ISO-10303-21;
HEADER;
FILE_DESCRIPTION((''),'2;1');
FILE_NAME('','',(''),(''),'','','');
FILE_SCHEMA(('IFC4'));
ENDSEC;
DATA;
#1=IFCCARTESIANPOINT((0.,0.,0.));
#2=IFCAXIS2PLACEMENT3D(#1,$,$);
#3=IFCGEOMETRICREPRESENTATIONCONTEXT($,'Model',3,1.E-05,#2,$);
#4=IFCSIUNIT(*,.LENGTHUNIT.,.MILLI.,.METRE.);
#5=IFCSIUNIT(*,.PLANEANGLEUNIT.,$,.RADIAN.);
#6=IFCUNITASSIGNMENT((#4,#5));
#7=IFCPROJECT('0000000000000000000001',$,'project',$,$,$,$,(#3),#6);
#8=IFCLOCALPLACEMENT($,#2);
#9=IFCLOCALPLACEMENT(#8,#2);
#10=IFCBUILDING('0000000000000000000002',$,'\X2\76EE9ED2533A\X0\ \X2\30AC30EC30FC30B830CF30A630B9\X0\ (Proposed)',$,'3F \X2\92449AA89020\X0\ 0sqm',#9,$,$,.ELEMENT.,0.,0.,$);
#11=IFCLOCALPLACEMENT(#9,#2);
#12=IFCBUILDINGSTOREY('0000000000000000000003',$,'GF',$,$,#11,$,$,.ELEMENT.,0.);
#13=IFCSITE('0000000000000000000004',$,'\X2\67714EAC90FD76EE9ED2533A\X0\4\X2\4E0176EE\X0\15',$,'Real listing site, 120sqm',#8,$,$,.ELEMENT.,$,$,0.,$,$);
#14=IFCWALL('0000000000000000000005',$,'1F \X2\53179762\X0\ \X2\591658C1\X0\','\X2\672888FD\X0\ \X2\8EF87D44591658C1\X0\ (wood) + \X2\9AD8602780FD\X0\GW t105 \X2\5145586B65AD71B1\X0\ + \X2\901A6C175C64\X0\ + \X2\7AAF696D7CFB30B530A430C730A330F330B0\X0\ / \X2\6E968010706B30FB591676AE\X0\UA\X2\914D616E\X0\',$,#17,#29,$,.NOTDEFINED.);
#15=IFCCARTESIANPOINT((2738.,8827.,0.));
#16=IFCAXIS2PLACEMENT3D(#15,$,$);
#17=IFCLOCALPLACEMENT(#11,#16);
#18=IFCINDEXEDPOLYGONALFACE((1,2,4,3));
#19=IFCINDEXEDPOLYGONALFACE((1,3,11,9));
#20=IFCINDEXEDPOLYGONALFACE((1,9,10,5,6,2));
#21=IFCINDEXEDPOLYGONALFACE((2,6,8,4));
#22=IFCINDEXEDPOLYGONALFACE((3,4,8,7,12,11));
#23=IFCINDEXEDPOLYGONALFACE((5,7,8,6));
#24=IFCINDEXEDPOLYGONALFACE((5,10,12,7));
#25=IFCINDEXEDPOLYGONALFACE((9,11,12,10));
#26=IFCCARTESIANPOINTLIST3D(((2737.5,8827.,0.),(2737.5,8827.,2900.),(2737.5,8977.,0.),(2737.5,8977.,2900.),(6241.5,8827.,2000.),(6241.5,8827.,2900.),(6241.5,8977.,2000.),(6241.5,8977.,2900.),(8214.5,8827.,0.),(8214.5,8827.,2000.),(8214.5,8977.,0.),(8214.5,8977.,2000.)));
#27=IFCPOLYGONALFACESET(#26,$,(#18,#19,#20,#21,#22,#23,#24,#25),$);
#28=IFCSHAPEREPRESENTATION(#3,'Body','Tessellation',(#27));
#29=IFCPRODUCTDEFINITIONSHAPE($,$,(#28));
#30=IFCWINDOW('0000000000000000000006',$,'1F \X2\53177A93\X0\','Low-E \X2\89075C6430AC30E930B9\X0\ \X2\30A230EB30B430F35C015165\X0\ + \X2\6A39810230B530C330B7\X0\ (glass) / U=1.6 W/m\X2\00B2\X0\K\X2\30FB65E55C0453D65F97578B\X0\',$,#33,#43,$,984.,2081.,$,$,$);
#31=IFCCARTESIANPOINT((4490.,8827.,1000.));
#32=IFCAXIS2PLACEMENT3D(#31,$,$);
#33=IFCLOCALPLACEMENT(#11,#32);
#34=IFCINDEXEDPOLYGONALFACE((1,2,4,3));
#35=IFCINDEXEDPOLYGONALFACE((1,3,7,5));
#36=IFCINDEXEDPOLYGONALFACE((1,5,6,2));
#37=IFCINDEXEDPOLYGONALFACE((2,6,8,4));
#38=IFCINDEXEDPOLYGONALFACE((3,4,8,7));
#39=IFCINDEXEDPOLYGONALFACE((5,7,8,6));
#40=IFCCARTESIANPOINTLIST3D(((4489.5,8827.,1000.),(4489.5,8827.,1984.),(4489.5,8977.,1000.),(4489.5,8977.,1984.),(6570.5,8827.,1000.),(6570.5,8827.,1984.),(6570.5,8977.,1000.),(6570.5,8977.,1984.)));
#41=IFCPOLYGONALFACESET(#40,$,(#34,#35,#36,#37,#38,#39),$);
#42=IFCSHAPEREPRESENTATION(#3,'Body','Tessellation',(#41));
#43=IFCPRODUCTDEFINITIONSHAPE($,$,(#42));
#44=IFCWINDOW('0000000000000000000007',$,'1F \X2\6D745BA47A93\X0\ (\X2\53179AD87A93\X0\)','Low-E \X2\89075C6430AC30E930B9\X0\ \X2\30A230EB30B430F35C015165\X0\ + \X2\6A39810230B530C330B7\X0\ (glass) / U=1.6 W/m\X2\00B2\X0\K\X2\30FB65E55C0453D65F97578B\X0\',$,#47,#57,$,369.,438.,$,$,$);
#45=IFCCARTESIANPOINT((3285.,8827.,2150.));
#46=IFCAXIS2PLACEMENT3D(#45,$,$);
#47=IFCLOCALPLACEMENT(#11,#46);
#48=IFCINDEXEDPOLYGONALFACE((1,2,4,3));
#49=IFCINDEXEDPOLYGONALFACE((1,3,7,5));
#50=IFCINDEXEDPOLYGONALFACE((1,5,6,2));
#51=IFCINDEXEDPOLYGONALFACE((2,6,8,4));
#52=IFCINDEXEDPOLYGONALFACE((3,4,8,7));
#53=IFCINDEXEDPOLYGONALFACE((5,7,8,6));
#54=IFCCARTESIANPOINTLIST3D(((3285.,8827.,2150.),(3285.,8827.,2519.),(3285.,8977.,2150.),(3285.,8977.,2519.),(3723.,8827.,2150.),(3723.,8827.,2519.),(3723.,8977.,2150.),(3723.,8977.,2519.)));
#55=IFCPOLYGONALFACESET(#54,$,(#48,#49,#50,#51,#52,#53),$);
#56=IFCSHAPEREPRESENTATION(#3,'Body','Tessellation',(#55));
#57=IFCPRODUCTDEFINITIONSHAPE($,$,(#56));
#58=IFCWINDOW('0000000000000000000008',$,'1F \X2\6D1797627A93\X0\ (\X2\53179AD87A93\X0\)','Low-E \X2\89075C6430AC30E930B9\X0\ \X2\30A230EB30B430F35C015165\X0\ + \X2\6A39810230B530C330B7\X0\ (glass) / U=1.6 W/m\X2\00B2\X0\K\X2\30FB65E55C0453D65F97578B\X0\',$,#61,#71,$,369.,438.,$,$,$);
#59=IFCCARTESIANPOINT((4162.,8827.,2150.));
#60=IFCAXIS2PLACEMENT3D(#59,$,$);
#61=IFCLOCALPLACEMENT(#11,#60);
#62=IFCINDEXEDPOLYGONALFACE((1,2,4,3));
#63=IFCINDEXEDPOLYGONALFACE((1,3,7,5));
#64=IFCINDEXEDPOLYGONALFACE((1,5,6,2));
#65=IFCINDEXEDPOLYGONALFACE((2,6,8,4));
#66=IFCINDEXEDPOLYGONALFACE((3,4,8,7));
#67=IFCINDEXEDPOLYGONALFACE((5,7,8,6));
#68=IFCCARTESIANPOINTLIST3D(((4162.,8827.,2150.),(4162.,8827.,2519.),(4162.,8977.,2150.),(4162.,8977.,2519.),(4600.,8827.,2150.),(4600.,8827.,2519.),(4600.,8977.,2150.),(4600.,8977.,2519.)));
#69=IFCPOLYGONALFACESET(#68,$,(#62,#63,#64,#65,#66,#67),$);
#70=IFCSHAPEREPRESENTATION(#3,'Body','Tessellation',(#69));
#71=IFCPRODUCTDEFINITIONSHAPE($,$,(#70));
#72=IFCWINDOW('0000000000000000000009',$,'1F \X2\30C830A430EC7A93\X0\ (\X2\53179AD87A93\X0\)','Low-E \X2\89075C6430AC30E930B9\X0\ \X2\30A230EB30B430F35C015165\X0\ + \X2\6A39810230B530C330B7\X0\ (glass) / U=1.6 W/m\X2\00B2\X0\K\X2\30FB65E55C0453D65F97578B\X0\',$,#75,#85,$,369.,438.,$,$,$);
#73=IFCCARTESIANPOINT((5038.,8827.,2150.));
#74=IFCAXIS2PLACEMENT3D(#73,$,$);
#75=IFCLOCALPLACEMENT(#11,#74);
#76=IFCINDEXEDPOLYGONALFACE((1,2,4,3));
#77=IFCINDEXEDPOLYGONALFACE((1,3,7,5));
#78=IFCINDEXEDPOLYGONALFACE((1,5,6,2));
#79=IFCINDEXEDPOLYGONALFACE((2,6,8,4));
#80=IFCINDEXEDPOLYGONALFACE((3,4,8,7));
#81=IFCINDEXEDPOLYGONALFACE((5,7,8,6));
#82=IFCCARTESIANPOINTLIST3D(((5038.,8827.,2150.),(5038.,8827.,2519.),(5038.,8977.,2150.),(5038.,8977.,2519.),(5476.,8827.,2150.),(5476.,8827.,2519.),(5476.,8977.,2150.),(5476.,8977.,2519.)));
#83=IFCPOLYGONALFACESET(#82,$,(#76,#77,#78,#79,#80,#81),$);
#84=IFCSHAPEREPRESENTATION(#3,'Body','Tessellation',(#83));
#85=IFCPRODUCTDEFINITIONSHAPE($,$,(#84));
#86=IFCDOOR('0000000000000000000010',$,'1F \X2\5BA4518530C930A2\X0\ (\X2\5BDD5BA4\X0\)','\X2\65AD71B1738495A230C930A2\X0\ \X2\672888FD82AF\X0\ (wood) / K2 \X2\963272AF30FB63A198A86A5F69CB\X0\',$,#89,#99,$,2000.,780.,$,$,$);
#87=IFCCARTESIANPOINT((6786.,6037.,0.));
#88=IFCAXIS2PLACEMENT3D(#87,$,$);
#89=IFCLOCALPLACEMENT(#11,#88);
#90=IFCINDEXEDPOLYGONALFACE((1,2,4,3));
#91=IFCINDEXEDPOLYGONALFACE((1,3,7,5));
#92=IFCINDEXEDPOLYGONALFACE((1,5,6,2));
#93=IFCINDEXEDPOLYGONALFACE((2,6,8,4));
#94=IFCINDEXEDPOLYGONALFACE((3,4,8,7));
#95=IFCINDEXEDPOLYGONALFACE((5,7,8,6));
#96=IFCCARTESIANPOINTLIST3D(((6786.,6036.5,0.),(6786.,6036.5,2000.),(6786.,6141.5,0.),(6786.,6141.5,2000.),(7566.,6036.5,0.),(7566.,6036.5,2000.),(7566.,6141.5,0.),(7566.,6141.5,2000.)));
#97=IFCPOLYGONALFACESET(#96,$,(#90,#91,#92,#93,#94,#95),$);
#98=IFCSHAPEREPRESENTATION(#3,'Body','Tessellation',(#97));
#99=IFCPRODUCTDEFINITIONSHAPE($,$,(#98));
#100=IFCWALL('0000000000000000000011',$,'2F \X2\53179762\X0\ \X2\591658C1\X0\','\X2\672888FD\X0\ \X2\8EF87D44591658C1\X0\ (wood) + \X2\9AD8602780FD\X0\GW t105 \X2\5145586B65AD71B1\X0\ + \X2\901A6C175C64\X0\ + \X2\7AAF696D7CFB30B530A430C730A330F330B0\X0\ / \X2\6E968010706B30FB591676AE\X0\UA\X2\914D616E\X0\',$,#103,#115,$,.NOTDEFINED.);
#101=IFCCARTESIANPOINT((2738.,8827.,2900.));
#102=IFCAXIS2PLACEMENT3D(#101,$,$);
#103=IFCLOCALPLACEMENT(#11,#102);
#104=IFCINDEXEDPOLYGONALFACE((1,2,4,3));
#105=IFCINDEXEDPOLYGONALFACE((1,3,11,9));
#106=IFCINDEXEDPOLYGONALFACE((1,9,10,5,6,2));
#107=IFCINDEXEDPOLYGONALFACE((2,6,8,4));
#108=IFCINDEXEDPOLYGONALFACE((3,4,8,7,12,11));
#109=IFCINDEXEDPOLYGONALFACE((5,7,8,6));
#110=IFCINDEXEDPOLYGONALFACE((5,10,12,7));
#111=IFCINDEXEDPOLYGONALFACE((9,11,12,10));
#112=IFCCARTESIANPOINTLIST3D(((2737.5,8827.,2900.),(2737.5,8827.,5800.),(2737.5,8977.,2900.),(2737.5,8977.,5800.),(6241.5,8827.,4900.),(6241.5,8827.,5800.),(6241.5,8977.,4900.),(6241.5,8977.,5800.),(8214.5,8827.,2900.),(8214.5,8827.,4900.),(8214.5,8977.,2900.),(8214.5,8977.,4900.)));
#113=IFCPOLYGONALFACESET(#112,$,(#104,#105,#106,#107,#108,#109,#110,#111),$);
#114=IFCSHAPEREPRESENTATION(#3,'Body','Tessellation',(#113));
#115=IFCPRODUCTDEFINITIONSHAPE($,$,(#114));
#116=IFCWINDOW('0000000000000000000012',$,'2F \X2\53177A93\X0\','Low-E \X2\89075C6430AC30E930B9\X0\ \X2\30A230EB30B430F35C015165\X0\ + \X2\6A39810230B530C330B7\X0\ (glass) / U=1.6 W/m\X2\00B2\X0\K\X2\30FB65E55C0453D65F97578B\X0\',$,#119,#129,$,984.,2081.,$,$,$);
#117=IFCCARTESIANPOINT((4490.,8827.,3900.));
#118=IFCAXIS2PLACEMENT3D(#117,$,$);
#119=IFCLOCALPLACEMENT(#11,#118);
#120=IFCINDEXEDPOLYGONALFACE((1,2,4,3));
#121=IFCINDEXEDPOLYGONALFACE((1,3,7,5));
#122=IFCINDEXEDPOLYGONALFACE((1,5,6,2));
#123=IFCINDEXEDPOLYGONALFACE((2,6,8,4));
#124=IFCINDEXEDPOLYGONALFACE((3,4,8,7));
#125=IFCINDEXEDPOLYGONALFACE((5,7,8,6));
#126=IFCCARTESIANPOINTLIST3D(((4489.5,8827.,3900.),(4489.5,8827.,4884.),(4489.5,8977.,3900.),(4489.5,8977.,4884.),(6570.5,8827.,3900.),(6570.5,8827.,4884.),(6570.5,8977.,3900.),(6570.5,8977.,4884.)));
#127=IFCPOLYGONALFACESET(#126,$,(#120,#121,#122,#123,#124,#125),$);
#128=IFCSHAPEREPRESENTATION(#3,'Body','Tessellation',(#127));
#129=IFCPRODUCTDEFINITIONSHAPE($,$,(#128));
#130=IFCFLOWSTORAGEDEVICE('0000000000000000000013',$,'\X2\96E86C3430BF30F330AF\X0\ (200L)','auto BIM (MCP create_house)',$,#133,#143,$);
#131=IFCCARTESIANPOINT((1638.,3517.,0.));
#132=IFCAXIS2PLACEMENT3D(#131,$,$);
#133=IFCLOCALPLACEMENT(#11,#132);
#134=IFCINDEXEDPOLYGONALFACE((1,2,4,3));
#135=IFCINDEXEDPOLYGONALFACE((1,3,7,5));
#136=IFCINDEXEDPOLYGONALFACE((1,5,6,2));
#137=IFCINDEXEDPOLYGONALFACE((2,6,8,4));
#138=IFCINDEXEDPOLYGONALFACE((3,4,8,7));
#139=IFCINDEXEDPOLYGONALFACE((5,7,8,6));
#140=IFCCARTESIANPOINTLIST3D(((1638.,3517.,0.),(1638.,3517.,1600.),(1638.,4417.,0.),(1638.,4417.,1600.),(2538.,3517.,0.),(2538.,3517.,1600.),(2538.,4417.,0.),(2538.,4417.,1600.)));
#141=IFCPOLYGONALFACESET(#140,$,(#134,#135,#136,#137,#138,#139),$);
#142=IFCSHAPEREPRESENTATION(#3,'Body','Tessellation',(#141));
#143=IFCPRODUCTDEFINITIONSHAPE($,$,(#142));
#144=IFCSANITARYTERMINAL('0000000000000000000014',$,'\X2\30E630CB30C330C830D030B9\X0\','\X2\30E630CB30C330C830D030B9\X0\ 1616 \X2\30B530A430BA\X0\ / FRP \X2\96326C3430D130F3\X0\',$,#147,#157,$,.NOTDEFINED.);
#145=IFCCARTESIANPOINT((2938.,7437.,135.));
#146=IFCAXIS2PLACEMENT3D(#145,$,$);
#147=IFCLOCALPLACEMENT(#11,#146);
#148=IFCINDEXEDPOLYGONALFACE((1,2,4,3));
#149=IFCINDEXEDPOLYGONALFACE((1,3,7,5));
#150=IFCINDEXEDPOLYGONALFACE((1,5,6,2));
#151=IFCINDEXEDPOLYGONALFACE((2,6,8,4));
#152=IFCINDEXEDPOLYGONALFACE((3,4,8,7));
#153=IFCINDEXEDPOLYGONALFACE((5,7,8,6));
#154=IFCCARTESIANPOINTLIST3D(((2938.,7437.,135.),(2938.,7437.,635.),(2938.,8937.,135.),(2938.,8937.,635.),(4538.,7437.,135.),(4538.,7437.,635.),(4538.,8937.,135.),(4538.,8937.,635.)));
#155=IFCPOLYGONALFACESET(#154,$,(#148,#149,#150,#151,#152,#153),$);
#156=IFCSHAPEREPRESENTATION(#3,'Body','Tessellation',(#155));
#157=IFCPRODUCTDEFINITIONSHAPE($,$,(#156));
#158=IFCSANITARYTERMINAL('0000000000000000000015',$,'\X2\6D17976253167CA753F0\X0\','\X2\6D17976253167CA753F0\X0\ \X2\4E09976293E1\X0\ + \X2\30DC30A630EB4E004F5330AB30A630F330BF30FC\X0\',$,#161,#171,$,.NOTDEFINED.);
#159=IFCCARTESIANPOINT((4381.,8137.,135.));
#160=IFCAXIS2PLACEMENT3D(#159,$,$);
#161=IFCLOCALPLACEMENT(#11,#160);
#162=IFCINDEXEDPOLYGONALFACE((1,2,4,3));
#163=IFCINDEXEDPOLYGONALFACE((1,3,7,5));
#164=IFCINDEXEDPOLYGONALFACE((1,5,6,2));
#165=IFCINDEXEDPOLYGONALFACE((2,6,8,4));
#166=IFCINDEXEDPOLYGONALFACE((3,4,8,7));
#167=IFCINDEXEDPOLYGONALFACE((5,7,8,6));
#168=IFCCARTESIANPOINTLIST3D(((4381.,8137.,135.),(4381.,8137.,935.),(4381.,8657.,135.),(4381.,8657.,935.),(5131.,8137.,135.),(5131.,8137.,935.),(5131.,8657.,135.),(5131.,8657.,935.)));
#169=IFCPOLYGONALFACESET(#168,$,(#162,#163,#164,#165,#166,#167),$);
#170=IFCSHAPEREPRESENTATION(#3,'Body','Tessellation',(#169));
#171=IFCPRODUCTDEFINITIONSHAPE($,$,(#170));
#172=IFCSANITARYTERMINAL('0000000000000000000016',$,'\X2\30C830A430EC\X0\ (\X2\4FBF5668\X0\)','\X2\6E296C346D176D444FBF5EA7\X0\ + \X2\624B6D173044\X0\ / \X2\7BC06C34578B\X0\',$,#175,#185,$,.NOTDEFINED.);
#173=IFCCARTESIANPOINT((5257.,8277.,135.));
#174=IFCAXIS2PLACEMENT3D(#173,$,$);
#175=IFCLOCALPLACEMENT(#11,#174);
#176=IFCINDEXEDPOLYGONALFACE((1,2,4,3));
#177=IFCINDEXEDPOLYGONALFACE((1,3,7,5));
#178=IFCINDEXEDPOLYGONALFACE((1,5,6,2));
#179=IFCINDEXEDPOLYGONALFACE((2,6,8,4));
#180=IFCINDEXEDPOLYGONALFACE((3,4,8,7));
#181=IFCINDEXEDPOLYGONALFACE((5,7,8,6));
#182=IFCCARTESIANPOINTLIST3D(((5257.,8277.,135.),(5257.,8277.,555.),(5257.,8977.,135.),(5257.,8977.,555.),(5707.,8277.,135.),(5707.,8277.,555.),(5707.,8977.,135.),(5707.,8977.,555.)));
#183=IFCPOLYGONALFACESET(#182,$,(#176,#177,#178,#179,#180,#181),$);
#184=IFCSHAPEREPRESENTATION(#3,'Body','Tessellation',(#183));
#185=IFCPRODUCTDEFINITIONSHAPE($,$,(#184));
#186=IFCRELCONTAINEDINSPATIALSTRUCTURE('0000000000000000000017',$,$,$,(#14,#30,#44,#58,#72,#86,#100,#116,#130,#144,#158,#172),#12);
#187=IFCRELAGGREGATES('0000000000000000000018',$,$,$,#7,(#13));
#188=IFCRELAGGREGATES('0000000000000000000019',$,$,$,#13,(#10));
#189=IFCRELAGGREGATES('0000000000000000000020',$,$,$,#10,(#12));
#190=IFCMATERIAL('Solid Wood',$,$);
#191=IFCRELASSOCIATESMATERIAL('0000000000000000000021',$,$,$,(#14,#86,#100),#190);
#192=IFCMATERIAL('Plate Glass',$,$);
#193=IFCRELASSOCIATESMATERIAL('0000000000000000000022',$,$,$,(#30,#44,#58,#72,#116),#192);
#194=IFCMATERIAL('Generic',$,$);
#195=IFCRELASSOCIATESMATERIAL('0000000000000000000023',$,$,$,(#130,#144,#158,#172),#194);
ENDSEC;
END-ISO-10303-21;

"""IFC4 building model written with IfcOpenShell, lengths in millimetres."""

from ifc_helpers import new_model, si_unit, frame, frame_2d, origin, place, context, project, spatial, rectangle, extrude, material, element, fill, save


model = new_model("IFC4")

# Units and contexts
model_context = context("Model", 3, precision=1e-05, world=origin())
ifc_project = project(units=[si_unit("LENGTHUNIT", "METRE", prefix="MILLI"), si_unit("PLANEANGLEUNIT", "RADIAN")], contexts=[model_context])

# Site, building, storey
site_placement = place(None, origin())
site = spatial("IfcSite", under=ifc_project, at=site_placement, Name="東京都目黒区4丁目15", ObjectType="Real listing site, 120sqm", CompositionType="ELEMENT", RefElevation=0.0)
building_placement = place(site_placement, origin())
building = spatial("IfcBuilding", under=site, at=building_placement, Name="目黒区 ガレージハウス (Proposed)", ObjectType="3F 鉄骨造 0sqm", CompositionType="ELEMENT", ElevationOfRefHeight=0.0, ElevationOfTerrain=0.0)
storey_placement = place(building_placement, origin())
storey = spatial("IfcBuildingStorey", under=building, at=storey_placement, Name="GF", CompositionType="ELEMENT", Elevation=0.0)

# Wall, openings, windows
ifc_material_1 = material(Name="Solid Wood")
wall_1_placement = place(storey_placement, frame((2738.0, 8827.0, 0.0)))
wall_1 = element("IfcWall", 1, at=wall_1_placement, inside=storey, material=ifc_material_1, Name="1F 北面 外壁", Description="木製 軸組外壁 (wood) + 高性能GW t105 充填断熱 + 通気層 + 窯業系サイディング / 準耐火・外皮UA配慮", PredefinedType="NOTDEFINED", context=model_context, shape_type="SweptSolid", body=[
    extrude(rectangle(XDim=5477.0, YDim=150.0, at=frame_2d((2738.0, 75.0))), frame((2738.0, 8827.0, 0.0)), (0.0, 0.0, 1.0), 2900.0),
])
opening_1_placement = place(storey_placement, frame((4490.0, 8827.0, 1000.0)))
opening_1 = element("IfcOpeningElement", 2, at=opening_1_placement, cuts=wall_1, PredefinedType="NOTDEFINED", context=model_context, shape_type="SweptSolid", body=[
    extrude(rectangle(XDim=2081.0, YDim=150.0, at=frame_2d((1040.0, 75.0))), frame((4490.0, 8827.0, 1000.0)), (0.0, 0.0, 1.0), 984.0),
])
opening_2_placement = place(storey_placement, frame((3285.0, 8827.0, 2150.0)))
opening_2 = element("IfcOpeningElement", 3, at=opening_2_placement, cuts=wall_1, PredefinedType="NOTDEFINED", context=model_context, shape_type="SweptSolid", body=[
    extrude(rectangle(XDim=438.0, YDim=150.0, at=frame_2d((219.0, 75.0))), frame((3285.0, 8827.0, 2150.0)), (0.0, 0.0, 1.0), 369.0),
])
opening_3_placement = place(storey_placement, frame((4162.0, 8827.0, 2150.0)))
opening_3 = element("IfcOpeningElement", 4, at=opening_3_placement, cuts=wall_1, PredefinedType="NOTDEFINED", context=model_context, shape_type="SweptSolid", body=[
    extrude(rectangle(XDim=438.0, YDim=150.0, at=frame_2d((219.0, 75.0))), frame((4162.0, 8827.0, 2150.0)), (0.0, 0.0, 1.0), 369.0),
])
opening_4_placement = place(storey_placement, frame((5038.0, 8827.0, 2150.0)))
opening_4 = element("IfcOpeningElement", 5, at=opening_4_placement, cuts=wall_1, PredefinedType="NOTDEFINED", context=model_context, shape_type="SweptSolid", body=[
    extrude(rectangle(XDim=438.0, YDim=150.0, at=frame_2d((219.0, 75.0))), frame((5038.0, 8827.0, 2150.0)), (0.0, 0.0, 1.0), 369.0),
])
ifc_material_2 = material(Name="Plate Glass")
window_1_placement = place(storey_placement, frame((4490.0, 8827.0, 1000.0)))
window_1 = element("IfcWindow", 6, at=window_1_placement, inside=storey, material=ifc_material_2, Name="1F 北窓", Description="Low-E 複層ガラス アルゴン封入 + 樹脂サッシ (glass) / U=1.6 W/m²K・日射取得型", OverallHeight=984.0, OverallWidth=2081.0, context=model_context, shape_type="SweptSolid", body=[
    extrude(rectangle(XDim=2081.0, YDim=150.0, at=frame_2d((1040.0, 75.0))), frame((4490.0, 8827.0, 1000.0)), (0.0, 0.0, 1.0), 984.0),
])
fill(opening_1, window_1)
window_2_placement = place(storey_placement, frame((3285.0, 8827.0, 2150.0)))
window_2 = element("IfcWindow", 7, at=window_2_placement, inside=storey, material=ifc_material_2, Name="1F 浴室窓 (北高窓)", Description="Low-E 複層ガラス アルゴン封入 + 樹脂サッシ (glass) / U=1.6 W/m²K・日射取得型", OverallHeight=369.0, OverallWidth=438.0, context=model_context, shape_type="SweptSolid", body=[
    extrude(rectangle(XDim=438.0, YDim=150.0, at=frame_2d((219.0, 75.0))), frame((3285.0, 8827.0, 2150.0)), (0.0, 0.0, 1.0), 369.0),
])
fill(opening_2, window_2)
window_3_placement = place(storey_placement, frame((4162.0, 8827.0, 2150.0)))
window_3 = element("IfcWindow", 8, at=window_3_placement, inside=storey, material=ifc_material_2, Name="1F 洗面窓 (北高窓)", Description="Low-E 複層ガラス アルゴン封入 + 樹脂サッシ (glass) / U=1.6 W/m²K・日射取得型", OverallHeight=369.0, OverallWidth=438.0, context=model_context, shape_type="SweptSolid", body=[
    extrude(rectangle(XDim=438.0, YDim=150.0, at=frame_2d((219.0, 75.0))), frame((4162.0, 8827.0, 2150.0)), (0.0, 0.0, 1.0), 369.0),
])
fill(opening_3, window_3)
window_4_placement = place(storey_placement, frame((5038.0, 8827.0, 2150.0)))
window_4 = element("IfcWindow", 9, at=window_4_placement, inside=storey, material=ifc_material_2, Name="1F トイレ窓 (北高窓)", Description="Low-E 複層ガラス アルゴン封入 + 樹脂サッシ (glass) / U=1.6 W/m²K・日射取得型", OverallHeight=369.0, OverallWidth=438.0, context=model_context, shape_type="SweptSolid", body=[
    extrude(rectangle(XDim=438.0, YDim=150.0, at=frame_2d((219.0, 75.0))), frame((5038.0, 8827.0, 2150.0)), (0.0, 0.0, 1.0), 369.0),
])
fill(opening_4, window_4)

# Door
door_1_placement = place(storey_placement, frame((6786.0, 6037.0, 0.0)))
element("IfcDoor", 10, at=door_1_placement, inside=storey, material=ifc_material_1, Name="1F 室内ドア (寝室)", Description="断熱玄関ドア 木製芯 (wood) / K2 防犯・採風機構", OverallHeight=2000.0, OverallWidth=780.0, context=model_context, shape_type="SweptSolid", body=[
    extrude(rectangle(XDim=780.0, YDim=105.0, at=frame_2d((390.0, 52.0))), frame((6786.0, 6037.0, 0.0)), (0.0, 0.0, 1.0), 2000.0),
])

# Wall, opening, window
wall_2_placement = place(storey_placement, frame((2738.0, 8827.0, 2900.0)))
wall_2 = element("IfcWall", 11, at=wall_2_placement, inside=storey, material=ifc_material_1, Name="2F 北面 外壁", Description="木製 軸組外壁 (wood) + 高性能GW t105 充填断熱 + 通気層 + 窯業系サイディング / 準耐火・外皮UA配慮", PredefinedType="NOTDEFINED", context=model_context, shape_type="SweptSolid", body=[
    extrude(rectangle(XDim=5477.0, YDim=150.0, at=frame_2d((2738.0, 75.0))), frame((2738.0, 8827.0, 2900.0)), (0.0, 0.0, 1.0), 2900.0),
])
opening_5_placement = place(storey_placement, frame((4490.0, 8827.0, 3900.0)))
opening_5 = element("IfcOpeningElement", 12, at=opening_5_placement, cuts=wall_2, PredefinedType="NOTDEFINED", context=model_context, shape_type="SweptSolid", body=[
    extrude(rectangle(XDim=2081.0, YDim=150.0, at=frame_2d((1040.0, 75.0))), frame((4490.0, 8827.0, 3900.0)), (0.0, 0.0, 1.0), 984.0),
])
window_5_placement = place(storey_placement, frame((4490.0, 8827.0, 3900.0)))
window_5 = element("IfcWindow", 13, at=window_5_placement, inside=storey, material=ifc_material_2, Name="2F 北窓", Description="Low-E 複層ガラス アルゴン封入 + 樹脂サッシ (glass) / U=1.6 W/m²K・日射取得型", OverallHeight=984.0, OverallWidth=2081.0, context=model_context, shape_type="SweptSolid", body=[
    extrude(rectangle(XDim=2081.0, YDim=150.0, at=frame_2d((1040.0, 75.0))), frame((4490.0, 8827.0, 3900.0)), (0.0, 0.0, 1.0), 984.0),
])
fill(opening_5, window_5)

# Flow storage device
ifc_material_3 = material(Name="Generic")
flow_storage_device_placement = place(storey_placement, frame((1638.0, 3517.0, 0.0)))
element("IfcFlowStorageDevice", 14, at=flow_storage_device_placement, inside=storey, material=ifc_material_3, Name="雨水タンク (200L)", Description="auto BIM (MCP create_house)", context=model_context, shape_type="SweptSolid", body=[
    extrude(rectangle(XDim=900.0, YDim=900.0, at=frame_2d((450.0, 450.0))), frame((1638.0, 3517.0, 0.0)), (0.0, 0.0, 1.0), 1600.0),
])

# Sanitary terminals
sanitary_terminal_1_placement = place(storey_placement, frame((2938.0, 7437.0, 135.0)))
element("IfcSanitaryTerminal", 15, at=sanitary_terminal_1_placement, inside=storey, material=ifc_material_3, Name="ユニットバス", Description="ユニットバス 1616 サイズ / FRP 防水パン", PredefinedType="NOTDEFINED", context=model_context, shape_type="SweptSolid", body=[
    extrude(rectangle(XDim=1600.0, YDim=1500.0, at=frame_2d((800.0, 750.0))), frame((2938.0, 7437.0, 135.0)), (0.0, 0.0, 1.0), 500.0),
])
sanitary_terminal_2_placement = place(storey_placement, frame((4381.0, 8137.0, 135.0)))
element("IfcSanitaryTerminal", 16, at=sanitary_terminal_2_placement, inside=storey, material=ifc_material_3, Name="洗面化粧台", Description="洗面化粧台 三面鏡 + ボウル一体カウンター", PredefinedType="NOTDEFINED", context=model_context, shape_type="SweptSolid", body=[
    extrude(rectangle(XDim=750.0, YDim=520.0, at=frame_2d((375.0, 260.0))), frame((4381.0, 8137.0, 135.0)), (0.0, 0.0, 1.0), 800.0),
])
sanitary_terminal_3_placement = place(storey_placement, frame((5257.0, 8277.0, 135.0)))
element("IfcSanitaryTerminal", 17, at=sanitary_terminal_3_placement, inside=storey, material=ifc_material_3, Name="トイレ (便器)", Description="温水洗浄便座 + 手洗い / 節水型", PredefinedType="NOTDEFINED", context=model_context, shape_type="SweptSolid", body=[
    extrude(rectangle(XDim=450.0, YDim=700.0, at=frame_2d((225.0, 350.0))), frame((5257.0, 8277.0, 135.0)), (0.0, 0.0, 1.0), 420.0),
])

save(model, "model.ifc")
